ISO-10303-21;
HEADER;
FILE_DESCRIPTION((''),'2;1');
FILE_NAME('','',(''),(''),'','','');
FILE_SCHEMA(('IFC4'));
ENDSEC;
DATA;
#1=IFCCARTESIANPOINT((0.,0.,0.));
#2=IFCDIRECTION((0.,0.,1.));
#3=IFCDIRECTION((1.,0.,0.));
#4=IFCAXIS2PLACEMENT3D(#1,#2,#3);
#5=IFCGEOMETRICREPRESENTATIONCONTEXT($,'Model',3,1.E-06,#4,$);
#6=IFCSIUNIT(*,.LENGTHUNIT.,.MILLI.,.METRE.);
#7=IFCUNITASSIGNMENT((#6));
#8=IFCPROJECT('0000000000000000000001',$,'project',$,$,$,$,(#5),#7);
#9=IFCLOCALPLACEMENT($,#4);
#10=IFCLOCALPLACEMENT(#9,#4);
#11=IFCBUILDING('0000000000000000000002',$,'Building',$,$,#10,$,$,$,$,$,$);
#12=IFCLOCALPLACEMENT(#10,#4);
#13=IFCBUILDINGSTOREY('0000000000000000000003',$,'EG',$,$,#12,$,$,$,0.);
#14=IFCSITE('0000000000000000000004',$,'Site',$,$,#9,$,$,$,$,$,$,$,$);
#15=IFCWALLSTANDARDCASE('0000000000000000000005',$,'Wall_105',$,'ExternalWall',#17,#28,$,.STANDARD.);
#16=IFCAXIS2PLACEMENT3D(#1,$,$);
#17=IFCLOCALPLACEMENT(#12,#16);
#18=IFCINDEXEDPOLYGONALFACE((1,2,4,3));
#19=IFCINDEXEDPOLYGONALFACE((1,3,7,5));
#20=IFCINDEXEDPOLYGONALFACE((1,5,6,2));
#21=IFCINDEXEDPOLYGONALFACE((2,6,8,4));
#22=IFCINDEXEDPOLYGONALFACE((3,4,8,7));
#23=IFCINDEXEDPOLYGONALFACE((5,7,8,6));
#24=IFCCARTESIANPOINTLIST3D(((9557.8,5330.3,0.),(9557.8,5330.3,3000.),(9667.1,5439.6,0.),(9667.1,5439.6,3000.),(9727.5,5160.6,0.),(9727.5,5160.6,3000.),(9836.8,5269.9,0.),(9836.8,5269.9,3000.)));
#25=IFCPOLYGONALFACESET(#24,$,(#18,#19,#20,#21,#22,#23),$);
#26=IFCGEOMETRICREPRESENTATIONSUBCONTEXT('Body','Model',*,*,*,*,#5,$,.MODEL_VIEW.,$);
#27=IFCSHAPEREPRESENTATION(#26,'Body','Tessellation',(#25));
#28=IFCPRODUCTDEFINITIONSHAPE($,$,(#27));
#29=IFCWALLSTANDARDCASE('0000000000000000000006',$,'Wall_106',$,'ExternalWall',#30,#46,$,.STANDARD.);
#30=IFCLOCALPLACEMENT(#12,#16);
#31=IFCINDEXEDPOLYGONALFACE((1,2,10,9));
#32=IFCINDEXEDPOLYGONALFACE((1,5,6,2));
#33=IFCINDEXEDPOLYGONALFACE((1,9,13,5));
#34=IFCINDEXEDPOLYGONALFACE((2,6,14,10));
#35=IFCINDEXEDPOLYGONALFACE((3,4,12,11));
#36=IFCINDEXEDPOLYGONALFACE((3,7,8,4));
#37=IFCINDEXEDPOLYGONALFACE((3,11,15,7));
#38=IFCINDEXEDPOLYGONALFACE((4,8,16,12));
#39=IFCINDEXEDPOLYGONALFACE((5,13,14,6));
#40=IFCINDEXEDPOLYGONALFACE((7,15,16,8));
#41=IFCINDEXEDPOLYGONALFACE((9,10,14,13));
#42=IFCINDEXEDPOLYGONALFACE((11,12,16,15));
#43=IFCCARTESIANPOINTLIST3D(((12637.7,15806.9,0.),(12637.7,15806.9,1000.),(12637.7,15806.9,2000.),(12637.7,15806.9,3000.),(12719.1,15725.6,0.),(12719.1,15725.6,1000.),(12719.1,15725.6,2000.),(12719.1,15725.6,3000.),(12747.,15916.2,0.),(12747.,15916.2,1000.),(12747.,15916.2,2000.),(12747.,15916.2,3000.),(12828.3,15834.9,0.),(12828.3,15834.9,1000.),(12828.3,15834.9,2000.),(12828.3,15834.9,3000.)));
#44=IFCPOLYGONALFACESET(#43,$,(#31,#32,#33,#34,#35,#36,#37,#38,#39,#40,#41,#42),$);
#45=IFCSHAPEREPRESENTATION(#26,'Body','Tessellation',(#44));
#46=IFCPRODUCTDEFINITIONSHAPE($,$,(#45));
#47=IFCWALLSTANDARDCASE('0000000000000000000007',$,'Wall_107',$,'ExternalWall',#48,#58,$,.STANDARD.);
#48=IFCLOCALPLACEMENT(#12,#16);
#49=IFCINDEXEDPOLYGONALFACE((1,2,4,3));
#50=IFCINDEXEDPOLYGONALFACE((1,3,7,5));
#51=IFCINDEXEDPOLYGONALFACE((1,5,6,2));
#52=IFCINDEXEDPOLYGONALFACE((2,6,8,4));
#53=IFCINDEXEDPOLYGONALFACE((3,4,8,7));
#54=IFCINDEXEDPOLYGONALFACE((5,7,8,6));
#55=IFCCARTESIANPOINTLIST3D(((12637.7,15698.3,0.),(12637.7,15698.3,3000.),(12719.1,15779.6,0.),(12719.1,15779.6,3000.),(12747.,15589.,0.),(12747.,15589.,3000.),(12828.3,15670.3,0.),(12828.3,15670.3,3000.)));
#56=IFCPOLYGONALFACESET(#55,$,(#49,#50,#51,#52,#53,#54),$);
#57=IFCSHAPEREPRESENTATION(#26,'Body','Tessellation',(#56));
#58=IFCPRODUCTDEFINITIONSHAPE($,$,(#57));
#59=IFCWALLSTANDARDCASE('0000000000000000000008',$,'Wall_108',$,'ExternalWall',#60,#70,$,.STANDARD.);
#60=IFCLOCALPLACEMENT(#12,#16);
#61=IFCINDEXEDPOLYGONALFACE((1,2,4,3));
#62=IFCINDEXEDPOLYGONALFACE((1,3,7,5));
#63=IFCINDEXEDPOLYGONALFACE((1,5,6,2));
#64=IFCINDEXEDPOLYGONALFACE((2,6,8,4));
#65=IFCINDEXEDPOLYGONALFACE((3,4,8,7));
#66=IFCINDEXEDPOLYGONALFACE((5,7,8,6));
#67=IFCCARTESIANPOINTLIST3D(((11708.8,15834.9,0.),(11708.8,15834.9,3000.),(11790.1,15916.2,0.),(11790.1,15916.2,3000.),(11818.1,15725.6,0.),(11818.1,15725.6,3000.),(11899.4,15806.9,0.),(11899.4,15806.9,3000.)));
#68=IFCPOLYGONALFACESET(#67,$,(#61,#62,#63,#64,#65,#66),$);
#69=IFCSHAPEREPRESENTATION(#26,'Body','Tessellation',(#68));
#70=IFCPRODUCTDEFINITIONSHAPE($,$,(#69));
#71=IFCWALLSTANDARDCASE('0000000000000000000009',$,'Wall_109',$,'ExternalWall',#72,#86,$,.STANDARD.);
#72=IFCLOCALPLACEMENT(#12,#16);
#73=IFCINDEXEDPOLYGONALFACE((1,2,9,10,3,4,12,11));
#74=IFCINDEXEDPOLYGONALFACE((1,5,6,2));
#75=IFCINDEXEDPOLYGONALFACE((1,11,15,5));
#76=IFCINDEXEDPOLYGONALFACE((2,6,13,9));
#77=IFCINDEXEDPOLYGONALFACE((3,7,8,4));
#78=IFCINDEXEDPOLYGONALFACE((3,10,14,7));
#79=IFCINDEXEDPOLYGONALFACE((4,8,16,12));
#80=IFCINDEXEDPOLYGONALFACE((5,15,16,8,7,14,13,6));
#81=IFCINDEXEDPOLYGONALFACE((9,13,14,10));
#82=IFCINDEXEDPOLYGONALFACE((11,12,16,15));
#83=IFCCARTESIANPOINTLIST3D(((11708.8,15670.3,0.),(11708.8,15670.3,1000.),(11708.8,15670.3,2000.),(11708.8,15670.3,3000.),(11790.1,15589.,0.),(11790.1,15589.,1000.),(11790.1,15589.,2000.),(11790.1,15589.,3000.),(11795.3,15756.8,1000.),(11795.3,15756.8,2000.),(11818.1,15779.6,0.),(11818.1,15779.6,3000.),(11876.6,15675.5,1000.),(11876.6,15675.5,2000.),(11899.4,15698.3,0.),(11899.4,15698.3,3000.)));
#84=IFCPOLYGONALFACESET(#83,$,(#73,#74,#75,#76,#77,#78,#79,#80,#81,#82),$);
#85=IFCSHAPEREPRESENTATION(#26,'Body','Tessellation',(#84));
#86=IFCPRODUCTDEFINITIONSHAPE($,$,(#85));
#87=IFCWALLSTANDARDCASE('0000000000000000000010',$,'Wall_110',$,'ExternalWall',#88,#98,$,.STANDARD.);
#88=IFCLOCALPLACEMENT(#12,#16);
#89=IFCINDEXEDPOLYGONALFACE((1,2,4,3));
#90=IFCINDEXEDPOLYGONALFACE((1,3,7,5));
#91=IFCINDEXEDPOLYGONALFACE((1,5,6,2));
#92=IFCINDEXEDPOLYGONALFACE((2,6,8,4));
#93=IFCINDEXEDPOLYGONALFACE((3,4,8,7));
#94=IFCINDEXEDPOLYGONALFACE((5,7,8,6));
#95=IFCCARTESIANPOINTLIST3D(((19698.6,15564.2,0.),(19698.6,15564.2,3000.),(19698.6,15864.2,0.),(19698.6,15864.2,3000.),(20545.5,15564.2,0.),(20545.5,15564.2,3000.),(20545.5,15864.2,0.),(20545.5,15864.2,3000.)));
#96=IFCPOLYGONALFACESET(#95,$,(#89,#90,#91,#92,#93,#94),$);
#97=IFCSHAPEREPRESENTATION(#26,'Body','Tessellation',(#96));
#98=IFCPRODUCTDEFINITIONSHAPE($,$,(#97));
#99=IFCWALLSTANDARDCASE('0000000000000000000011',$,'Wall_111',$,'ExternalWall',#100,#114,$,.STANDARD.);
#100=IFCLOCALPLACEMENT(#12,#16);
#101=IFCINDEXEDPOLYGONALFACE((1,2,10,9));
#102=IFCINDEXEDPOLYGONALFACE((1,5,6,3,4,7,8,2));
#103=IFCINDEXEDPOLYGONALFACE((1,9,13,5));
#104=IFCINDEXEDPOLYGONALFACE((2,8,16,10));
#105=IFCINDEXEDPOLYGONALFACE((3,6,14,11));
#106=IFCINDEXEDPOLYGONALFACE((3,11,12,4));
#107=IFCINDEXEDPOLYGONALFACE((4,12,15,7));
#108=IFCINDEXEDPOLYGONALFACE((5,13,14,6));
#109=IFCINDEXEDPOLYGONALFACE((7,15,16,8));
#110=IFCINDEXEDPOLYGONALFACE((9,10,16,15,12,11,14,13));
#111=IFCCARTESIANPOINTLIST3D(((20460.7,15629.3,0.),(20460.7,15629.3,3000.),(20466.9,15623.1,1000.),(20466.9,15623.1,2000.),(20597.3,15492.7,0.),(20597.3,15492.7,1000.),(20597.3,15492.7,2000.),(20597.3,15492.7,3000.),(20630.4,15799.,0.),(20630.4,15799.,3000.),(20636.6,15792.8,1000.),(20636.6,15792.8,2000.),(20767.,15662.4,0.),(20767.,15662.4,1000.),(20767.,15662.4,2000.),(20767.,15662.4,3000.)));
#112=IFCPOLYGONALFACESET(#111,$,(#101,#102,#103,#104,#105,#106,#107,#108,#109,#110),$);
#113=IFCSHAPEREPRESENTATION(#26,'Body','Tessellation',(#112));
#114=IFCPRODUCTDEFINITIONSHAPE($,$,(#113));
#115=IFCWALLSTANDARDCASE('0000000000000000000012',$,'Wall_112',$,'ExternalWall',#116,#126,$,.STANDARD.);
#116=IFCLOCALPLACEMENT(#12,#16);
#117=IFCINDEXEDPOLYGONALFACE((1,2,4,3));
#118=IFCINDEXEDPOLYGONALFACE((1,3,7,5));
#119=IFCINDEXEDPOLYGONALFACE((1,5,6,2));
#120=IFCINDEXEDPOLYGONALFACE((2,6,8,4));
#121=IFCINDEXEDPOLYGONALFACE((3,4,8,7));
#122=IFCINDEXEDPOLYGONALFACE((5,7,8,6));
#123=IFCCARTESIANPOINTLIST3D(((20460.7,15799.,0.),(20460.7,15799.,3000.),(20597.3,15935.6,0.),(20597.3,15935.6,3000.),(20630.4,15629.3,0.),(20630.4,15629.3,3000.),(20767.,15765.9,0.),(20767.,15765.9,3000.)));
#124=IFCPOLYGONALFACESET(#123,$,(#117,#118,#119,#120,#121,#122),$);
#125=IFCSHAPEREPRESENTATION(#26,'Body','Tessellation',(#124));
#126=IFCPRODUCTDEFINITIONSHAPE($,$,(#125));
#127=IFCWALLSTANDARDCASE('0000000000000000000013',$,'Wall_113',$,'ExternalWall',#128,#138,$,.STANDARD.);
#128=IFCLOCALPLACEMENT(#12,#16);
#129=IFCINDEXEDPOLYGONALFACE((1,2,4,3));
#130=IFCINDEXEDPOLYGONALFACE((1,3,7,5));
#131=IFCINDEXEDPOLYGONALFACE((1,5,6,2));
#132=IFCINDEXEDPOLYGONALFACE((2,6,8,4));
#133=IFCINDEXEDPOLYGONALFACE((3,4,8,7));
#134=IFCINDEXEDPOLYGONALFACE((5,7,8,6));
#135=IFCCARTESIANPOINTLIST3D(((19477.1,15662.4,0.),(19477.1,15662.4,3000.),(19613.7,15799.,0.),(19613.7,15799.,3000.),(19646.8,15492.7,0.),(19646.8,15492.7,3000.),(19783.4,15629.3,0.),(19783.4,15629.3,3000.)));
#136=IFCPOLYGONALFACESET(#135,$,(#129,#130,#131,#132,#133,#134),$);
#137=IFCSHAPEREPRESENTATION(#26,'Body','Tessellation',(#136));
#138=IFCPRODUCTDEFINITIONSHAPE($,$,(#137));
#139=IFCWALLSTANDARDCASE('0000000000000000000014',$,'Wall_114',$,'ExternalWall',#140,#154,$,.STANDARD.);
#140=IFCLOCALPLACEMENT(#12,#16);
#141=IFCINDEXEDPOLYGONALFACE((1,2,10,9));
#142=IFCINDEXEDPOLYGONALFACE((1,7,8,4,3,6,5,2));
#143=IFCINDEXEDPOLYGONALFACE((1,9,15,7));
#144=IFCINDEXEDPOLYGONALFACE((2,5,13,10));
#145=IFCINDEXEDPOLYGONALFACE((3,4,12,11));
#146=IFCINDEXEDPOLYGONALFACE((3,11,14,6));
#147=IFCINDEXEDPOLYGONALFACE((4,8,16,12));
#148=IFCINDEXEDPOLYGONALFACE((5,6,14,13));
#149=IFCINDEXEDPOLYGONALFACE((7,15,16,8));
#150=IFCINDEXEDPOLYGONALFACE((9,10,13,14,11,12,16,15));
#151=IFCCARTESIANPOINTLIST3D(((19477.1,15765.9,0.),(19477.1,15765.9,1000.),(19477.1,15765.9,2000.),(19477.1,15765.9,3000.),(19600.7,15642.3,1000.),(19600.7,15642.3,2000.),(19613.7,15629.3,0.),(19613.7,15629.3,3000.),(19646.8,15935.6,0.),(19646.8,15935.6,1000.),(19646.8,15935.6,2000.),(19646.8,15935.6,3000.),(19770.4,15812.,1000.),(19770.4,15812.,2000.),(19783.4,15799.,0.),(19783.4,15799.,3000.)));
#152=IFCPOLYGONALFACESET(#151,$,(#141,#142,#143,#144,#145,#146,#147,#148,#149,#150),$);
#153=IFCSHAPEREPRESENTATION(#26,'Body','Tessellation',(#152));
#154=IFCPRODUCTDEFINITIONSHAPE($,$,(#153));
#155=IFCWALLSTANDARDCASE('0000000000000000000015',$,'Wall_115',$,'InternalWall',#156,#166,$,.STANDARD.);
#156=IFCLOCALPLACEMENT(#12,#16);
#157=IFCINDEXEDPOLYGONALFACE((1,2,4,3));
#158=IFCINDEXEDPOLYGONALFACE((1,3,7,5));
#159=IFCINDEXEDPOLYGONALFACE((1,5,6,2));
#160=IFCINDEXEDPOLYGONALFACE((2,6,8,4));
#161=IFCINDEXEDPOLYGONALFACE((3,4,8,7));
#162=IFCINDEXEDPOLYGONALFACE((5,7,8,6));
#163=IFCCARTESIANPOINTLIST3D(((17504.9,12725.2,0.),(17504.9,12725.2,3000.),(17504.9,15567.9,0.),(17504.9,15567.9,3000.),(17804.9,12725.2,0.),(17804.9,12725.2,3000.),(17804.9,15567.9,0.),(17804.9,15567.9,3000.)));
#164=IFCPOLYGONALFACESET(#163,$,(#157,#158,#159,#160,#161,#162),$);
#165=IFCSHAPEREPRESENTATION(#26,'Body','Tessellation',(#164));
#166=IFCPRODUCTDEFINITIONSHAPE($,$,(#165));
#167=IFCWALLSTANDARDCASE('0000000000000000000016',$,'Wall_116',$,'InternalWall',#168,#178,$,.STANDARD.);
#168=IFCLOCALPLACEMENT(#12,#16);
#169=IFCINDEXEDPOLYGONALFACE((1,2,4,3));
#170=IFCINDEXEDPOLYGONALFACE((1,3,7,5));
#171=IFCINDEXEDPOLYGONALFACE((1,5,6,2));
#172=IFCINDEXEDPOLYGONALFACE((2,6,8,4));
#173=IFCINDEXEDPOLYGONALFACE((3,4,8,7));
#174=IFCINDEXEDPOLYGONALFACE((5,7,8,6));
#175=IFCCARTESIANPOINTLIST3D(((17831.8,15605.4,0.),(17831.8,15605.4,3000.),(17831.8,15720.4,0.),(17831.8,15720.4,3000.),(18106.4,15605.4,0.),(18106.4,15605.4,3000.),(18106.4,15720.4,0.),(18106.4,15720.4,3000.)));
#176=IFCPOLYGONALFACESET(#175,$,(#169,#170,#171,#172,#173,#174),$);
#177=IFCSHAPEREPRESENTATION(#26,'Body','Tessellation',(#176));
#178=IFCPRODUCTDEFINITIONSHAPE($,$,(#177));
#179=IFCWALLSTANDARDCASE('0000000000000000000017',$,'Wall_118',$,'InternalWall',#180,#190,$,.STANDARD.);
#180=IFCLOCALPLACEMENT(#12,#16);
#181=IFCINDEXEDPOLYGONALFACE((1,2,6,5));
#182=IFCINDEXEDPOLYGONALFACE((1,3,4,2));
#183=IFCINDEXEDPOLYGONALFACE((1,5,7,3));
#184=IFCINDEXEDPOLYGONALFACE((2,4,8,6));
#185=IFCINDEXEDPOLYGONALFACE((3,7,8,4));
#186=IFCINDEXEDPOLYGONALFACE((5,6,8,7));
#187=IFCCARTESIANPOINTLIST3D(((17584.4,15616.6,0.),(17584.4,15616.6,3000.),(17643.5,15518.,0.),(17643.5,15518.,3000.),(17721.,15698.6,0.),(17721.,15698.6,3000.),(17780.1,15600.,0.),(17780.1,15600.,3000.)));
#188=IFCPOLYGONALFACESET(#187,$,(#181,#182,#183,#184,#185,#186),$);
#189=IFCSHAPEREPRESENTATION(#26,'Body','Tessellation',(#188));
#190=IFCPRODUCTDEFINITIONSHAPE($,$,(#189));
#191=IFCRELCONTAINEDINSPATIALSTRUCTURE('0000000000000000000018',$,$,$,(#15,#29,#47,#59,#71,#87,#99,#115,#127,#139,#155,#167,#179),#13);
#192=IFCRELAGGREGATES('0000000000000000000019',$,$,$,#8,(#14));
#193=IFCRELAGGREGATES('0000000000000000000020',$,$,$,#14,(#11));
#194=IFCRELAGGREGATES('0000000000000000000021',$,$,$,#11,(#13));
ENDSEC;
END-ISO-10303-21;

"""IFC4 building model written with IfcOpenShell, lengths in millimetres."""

from ifc_helpers import new_model, si_unit, frame, origin_with_axes, place, context, subcontext, project, spatial, rectangle, extrude, element, save


model = new_model("IFC4")

# Units and contexts
model_context = context("Model", 3, precision=1e-06, world=origin_with_axes())
body_context = subcontext(model_context, "Body", "Model", "MODEL_VIEW")
ifc_project = project(units=[si_unit("LENGTHUNIT", "METRE", prefix="MILLI")], contexts=[model_context])

# Site, building, storey
site_placement = place(None, origin_with_axes())
site = spatial("IfcSite", under=ifc_project, at=site_placement, Name="Site")
building_placement = place(site_placement, origin_with_axes())
building = spatial("IfcBuilding", under=site, at=building_placement, Name="Building")
storey_placement = place(building_placement, origin_with_axes())
storey = spatial("IfcBuildingStorey", under=building, at=storey_placement, Name="EG", Elevation=0.0)

# Wall
wall_1_placement = place(storey_placement, origin_with_axes())
element("IfcWallStandardCase", 1, at=wall_1_placement, inside=storey, Name="Wall_105", ObjectType="ExternalWall", PredefinedType="STANDARD", context=body_context, shape_type="SweptSolid", body=[
    extrude(rectangle(XDim=154.6, YDim=240.0), frame((9697.3, 5300.1, 0.0), z_axis=(0.0, 0.0, 1.0), x_axis=(0.707107, 0.707107, 0.0)), (0.0, 0.0, 1.0), 3000.0),
])

# Wall, opening
wall_2_placement = place(storey_placement, origin_with_axes())
wall_2 = element("IfcWallStandardCase", 2, at=wall_2_placement, inside=storey, Name="Wall_106", ObjectType="ExternalWall", PredefinedType="STANDARD", context=body_context, shape_type="SweptSolid", body=[
    extrude(rectangle(XDim=154.6, YDim=115.0), frame((12733.0, 15820.9, 0.0), z_axis=(0.0, 0.0, 1.0), x_axis=(0.707107, 0.707107, 0.0)), (0.0, 0.0, 1.0), 3000.0),
])
opening_1_placement = place(wall_2_placement, origin_with_axes())
element("IfcOpeningElement", 3, at=opening_1_placement, inside=storey, cuts=wall_2, context=body_context, shape_type="SweptSolid", body=[
    extrude(rectangle(XDim=1086.4, YDim=115.0), frame((13045.9, 16133.8, 1000.0), z_axis=(0.0, 0.0, 1.0), x_axis=(0.707107, 0.707107, 0.0)), (0.0, 0.0, 1.0), 1000.0),
])

# Walls
wall_3_placement = place(storey_placement, origin_with_axes())
element("IfcWallStandardCase", 4, at=wall_3_placement, inside=storey, Name="Wall_107", ObjectType="ExternalWall", PredefinedType="STANDARD", context=body_context, shape_type="SweptSolid", body=[
    extrude(rectangle(XDim=154.6, YDim=115.0), frame((12733.0, 15684.3, 0.0), z_axis=(0.0, 0.0, 1.0), x_axis=(0.707107, -0.707107, 0.0)), (0.0, 0.0, 1.0), 3000.0),
])
wall_4_placement = place(storey_placement, origin_with_axes())
element("IfcWallStandardCase", 5, at=wall_4_placement, inside=storey, Name="Wall_108", ObjectType="ExternalWall", PredefinedType="STANDARD", context=body_context, shape_type="SweptSolid", body=[
    extrude(rectangle(XDim=154.6, YDim=115.0), frame((11804.1, 15820.9, 0.0), z_axis=(0.0, 0.0, 1.0), x_axis=(-0.707107, 0.707107, 0.0)), (0.0, 0.0, 1.0), 3000.0),
])

# Wall, opening
wall_5_placement = place(storey_placement, origin_with_axes())
wall_5 = element("IfcWallStandardCase", 6, at=wall_5_placement, inside=storey, Name="Wall_109", ObjectType="ExternalWall", PredefinedType="STANDARD", context=body_context, shape_type="SweptSolid", body=[
    extrude(rectangle(XDim=154.6, YDim=115.0), frame((11804.1, 15684.3, 0.0), z_axis=(0.0, 0.0, 1.0), x_axis=(-0.707107, -0.707107, 0.0)), (0.0, 0.0, 1.0), 3000.0),
])
opening_2_placement = place(wall_5_placement, origin_with_axes())
element("IfcOpeningElement", 7, at=opening_2_placement, inside=storey, cuts=wall_5, context=body_context, shape_type="SweptSolid", body=[
    extrude(rectangle(XDim=1141.7, YDim=115.0), frame((11432.3, 15312.5, 1000.0), z_axis=(0.0, 0.0, 1.0), x_axis=(-0.707107, -0.707107, 0.0)), (0.0, 0.0, 1.0), 1000.0),
])

# Wall
wall_6_placement = place(storey_placement, origin_with_axes())
element("IfcWallStandardCase", 8, at=wall_6_placement, inside=storey, Name="Wall_110", ObjectType="ExternalWall", PredefinedType="STANDARD", context=body_context, shape_type="SweptSolid", body=[
    extrude(rectangle(XDim=847.0, YDim=300.0), frame((20122.0, 15714.2, 0.0), z_axis=(0.0, 0.0, 1.0), x_axis=(-1.0, 0.0, 0.0)), (0.0, 0.0, 1.0), 3000.0),
])

# Wall, opening
wall_7_placement = place(storey_placement, origin_with_axes())
wall_7 = element("IfcWallStandardCase", 9, at=wall_7_placement, inside=storey, Name="Wall_111", ObjectType="ExternalWall", PredefinedType="STANDARD", context=body_context, shape_type="SweptSolid", body=[
    extrude(rectangle(XDim=193.2, YDim=240.0), frame((20613.9, 15645.9, 0.0), z_axis=(0.0, 0.0, 1.0), x_axis=(0.707107, -0.707107, 0.0)), (0.0, 0.0, 1.0), 3000.0),
])
opening_3_placement = place(wall_7_placement, origin_with_axes())
element("IfcOpeningElement", 10, at=opening_3_placement, inside=storey, cuts=wall_7, context=body_context, shape_type="SweptSolid", body=[
    extrude(rectangle(XDim=2062.4, YDim=240.0), frame((21280.9, 14978.8, 1000.0), z_axis=(0.0, 0.0, 1.0), x_axis=(0.707107, -0.707107, 0.0)), (0.0, 0.0, 1.0), 1000.0),
])

# Walls
wall_8_placement = place(storey_placement, origin_with_axes())
element("IfcWallStandardCase", 11, at=wall_8_placement, inside=storey, Name="Wall_112", ObjectType="ExternalWall", PredefinedType="STANDARD", context=body_context, shape_type="SweptSolid", body=[
    extrude(rectangle(XDim=193.2, YDim=240.0), frame((20613.9, 15782.5, 0.0), z_axis=(0.0, 0.0, 1.0), x_axis=(0.707107, 0.707107, 0.0)), (0.0, 0.0, 1.0), 3000.0),
])
wall_9_placement = place(storey_placement, origin_with_axes())
element("IfcWallStandardCase", 12, at=wall_9_placement, inside=storey, Name="Wall_113", ObjectType="ExternalWall", PredefinedType="STANDARD", context=body_context, shape_type="SweptSolid", body=[
    extrude(rectangle(XDim=193.2, YDim=240.0), frame((19630.2, 15645.9, 0.0), z_axis=(0.0, 0.0, 1.0), x_axis=(-0.707107, -0.707107, 0.0)), (0.0, 0.0, 1.0), 3000.0),
])

# Wall, opening
wall_10_placement = place(storey_placement, origin_with_axes())
wall_10 = element("IfcWallStandardCase", 13, at=wall_10_placement, inside=storey, Name="Wall_114", ObjectType="ExternalWall", PredefinedType="STANDARD", context=body_context, shape_type="SweptSolid", body=[
    extrude(rectangle(XDim=193.2, YDim=240.0), frame((19630.2, 15782.5, 0.0), z_axis=(0.0, 0.0, 1.0), x_axis=(-0.707107, 0.707107, 0.0)), (0.0, 0.0, 1.0), 3000.0),
])
opening_4_placement = place(wall_10_placement, origin_with_axes())
element("IfcOpeningElement", 14, at=opening_4_placement, inside=storey, cuts=wall_10, context=body_context, shape_type="SweptSolid", body=[
    extrude(rectangle(XDim=1104.9, YDim=240.0), frame((19294.9, 16117.8, 1000.0), z_axis=(0.0, 0.0, 1.0), x_axis=(-0.707107, 0.707107, 0.0)), (0.0, 0.0, 1.0), 1000.0),
])

# Walls
wall_11_placement = place(storey_placement, origin_with_axes())
element("IfcWallStandardCase", 15, at=wall_11_placement, inside=storey, Name="Wall_115", ObjectType="InternalWall", PredefinedType="STANDARD", context=body_context, shape_type="SweptSolid", body=[
    extrude(rectangle(XDim=2842.7, YDim=300.0), frame((17654.9, 14146.6, 0.0), z_axis=(0.0, 0.0, 1.0), x_axis=(0.0, -1.0, 0.0)), (0.0, 0.0, 1.0), 3000.0),
])
wall_12_placement = place(storey_placement, origin_with_axes())
element("IfcWallStandardCase", 16, at=wall_12_placement, inside=storey, Name="Wall_116", ObjectType="InternalWall", PredefinedType="STANDARD", context=body_context, shape_type="SweptSolid", body=[
    extrude(rectangle(XDim=274.6, YDim=115.0), frame((17969.1, 15662.9, 0.0), z_axis=(0.0, 0.0, 1.0), x_axis=(1.0, 0.0, 0.0)), (0.0, 0.0, 1.0), 3000.0),
])

# Wall
wall_13_placement = place(storey_placement, origin_with_axes())
element("IfcWallStandardCase", 17, at=wall_13_placement, inside=storey, Name="Wall_118", ObjectType="InternalWall", PredefinedType="STANDARD", context=body_context, shape_type="SweptSolid", body=[
    extrude(rectangle(XDim=159.3, YDim=115.0), frame((17682.2, 15608.3, 0.0), z_axis=(0.0, 0.0, 1.0), x_axis=(0.857493, 0.514496, 0.0)), (0.0, 0.0, 1.0), 3000.0),
])

save(model, "model.ifc")
